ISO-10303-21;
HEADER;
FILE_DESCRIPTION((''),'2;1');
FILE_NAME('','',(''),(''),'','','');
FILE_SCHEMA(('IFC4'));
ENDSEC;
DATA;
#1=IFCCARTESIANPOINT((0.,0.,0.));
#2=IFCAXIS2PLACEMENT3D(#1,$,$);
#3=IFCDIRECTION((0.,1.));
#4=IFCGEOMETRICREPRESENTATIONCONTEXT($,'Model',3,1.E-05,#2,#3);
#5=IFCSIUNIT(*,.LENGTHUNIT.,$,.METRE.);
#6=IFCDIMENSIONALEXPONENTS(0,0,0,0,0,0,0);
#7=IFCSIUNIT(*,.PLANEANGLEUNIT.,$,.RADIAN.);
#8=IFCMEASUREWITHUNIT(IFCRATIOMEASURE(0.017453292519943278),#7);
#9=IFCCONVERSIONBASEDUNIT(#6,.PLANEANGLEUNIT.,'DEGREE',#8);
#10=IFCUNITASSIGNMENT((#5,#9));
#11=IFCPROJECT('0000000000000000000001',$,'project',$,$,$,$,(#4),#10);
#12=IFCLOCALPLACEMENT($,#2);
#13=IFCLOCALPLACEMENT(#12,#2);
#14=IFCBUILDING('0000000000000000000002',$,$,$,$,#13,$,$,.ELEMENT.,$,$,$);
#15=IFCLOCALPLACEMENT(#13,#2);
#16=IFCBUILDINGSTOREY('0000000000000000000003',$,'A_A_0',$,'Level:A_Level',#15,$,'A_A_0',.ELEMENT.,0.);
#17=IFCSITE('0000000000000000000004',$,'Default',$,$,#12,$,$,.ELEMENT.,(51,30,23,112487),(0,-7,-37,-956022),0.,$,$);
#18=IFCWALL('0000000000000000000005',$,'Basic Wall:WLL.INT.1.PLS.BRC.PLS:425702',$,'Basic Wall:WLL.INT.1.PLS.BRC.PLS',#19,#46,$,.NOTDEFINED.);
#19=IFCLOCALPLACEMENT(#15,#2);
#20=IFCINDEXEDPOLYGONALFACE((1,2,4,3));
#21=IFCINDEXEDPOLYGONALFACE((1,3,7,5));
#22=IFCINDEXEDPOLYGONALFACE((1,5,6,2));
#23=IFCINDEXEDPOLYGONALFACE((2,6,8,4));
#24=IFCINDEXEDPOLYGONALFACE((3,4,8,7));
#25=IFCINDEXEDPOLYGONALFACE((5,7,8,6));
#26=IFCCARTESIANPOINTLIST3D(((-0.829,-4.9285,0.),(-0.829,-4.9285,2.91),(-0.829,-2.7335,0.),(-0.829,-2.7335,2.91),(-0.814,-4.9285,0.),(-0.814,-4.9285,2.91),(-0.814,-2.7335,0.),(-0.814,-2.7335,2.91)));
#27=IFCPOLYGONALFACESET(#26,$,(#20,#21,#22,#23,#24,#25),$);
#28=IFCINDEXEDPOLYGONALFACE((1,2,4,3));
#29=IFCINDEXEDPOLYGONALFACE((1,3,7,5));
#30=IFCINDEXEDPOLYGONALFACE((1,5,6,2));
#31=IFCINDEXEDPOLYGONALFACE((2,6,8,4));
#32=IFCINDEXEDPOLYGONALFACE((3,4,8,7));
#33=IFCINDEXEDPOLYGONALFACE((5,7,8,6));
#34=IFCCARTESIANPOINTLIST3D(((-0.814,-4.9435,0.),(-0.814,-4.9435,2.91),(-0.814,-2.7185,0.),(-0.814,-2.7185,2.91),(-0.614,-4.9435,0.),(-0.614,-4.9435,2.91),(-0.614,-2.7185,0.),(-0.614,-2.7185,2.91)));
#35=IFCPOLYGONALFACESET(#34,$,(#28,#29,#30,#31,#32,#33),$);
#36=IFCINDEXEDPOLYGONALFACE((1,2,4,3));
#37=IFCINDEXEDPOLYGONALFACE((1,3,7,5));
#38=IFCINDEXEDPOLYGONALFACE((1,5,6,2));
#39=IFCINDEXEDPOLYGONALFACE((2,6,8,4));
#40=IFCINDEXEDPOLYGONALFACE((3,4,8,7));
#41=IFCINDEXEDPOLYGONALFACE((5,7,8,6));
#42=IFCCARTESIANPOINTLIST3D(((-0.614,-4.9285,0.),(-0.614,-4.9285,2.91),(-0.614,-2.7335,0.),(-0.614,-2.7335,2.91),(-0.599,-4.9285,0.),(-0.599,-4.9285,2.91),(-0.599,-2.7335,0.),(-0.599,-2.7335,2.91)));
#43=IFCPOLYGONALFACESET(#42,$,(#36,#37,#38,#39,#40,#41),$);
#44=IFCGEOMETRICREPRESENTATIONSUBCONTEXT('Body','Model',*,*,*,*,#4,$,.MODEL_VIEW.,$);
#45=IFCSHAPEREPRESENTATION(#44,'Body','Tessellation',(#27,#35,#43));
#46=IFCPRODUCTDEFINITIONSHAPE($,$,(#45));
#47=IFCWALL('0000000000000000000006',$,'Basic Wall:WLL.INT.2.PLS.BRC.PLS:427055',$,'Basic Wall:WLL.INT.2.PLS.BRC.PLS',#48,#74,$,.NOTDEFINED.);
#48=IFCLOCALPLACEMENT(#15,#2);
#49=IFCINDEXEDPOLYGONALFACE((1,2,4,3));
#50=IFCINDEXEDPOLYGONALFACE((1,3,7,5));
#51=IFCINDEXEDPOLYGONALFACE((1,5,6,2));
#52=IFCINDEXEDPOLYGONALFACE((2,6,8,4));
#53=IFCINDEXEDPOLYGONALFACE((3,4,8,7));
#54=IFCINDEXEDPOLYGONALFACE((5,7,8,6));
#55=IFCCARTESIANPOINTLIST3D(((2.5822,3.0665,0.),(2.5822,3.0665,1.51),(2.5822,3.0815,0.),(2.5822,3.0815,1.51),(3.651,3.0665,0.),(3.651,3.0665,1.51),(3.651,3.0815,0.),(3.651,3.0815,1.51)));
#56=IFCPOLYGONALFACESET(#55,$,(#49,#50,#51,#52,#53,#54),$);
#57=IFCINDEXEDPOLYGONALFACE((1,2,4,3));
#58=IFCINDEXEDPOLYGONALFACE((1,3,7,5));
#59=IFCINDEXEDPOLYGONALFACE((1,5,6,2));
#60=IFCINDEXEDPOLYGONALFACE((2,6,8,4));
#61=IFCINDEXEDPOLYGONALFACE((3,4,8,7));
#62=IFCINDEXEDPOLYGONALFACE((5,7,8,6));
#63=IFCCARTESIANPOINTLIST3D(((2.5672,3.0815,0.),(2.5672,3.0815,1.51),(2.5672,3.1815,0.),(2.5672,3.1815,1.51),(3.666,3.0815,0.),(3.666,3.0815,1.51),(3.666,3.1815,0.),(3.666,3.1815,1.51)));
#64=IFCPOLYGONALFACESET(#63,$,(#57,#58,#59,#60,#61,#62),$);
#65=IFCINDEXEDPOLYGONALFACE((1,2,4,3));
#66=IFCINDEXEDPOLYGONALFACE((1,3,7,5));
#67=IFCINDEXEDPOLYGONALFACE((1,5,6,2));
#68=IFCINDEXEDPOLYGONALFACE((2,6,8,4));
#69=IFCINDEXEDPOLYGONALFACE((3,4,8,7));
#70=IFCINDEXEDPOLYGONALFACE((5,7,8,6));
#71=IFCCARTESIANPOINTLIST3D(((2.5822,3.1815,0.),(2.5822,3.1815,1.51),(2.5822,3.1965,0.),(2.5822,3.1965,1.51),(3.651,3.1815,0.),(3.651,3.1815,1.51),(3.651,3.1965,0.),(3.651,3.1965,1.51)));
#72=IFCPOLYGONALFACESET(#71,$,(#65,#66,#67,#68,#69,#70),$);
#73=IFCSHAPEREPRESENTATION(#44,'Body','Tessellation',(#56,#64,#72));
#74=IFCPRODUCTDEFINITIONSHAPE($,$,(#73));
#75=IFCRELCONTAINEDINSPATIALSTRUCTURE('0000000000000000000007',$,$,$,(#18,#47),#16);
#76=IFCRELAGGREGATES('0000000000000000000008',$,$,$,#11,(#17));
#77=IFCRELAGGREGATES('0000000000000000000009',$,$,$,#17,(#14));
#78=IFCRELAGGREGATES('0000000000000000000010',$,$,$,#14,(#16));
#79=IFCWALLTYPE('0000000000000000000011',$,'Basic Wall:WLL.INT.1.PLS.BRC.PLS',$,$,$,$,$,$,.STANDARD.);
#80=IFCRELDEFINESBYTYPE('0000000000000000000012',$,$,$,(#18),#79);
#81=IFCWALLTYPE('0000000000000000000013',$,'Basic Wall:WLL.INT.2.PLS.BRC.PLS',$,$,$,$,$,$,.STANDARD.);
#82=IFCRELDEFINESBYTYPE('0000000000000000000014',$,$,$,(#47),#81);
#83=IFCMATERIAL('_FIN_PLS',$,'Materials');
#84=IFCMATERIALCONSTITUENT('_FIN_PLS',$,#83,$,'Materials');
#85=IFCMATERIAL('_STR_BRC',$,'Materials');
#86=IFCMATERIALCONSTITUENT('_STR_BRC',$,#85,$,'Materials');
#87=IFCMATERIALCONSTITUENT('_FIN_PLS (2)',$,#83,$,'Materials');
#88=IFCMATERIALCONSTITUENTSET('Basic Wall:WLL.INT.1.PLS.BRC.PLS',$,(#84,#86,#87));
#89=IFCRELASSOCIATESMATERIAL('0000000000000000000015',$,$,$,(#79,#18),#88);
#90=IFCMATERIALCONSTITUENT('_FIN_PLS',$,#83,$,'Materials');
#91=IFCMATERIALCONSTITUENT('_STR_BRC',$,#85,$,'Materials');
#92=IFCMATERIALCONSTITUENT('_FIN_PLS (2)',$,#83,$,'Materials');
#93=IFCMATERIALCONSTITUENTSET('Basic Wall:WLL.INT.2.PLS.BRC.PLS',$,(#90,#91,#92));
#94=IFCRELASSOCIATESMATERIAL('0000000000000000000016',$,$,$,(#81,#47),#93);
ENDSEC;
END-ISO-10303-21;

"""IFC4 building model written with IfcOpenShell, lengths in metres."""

from ifc_helpers import new_model, entity, si_unit, converted_unit, direction, frame, origin, place, context, subcontext, project, spatial, indexed_curve, outline, extrude, material, constituent, constituent_set, type_object, element, save


model = new_model("IFC4")

# Units and contexts
model_context = context("Model", 3, precision=1e-05, world=origin(), true_north=direction((0.0, 1.0)))
body_context = subcontext(model_context, "Body", "Model", "MODEL_VIEW")
ifc_project = project(units=[si_unit("LENGTHUNIT", "METRE"), converted_unit("PLANEANGLEUNIT", "DEGREE", entity("IfcRatioMeasure", 0.017453292519943278), si_unit("PLANEANGLEUNIT", "RADIAN"), dimensions=[0, 0, 0, 0, 0, 0, 0])], contexts=[model_context])

# Site, building, storey
site_placement = place(None, origin())
site = spatial("IfcSite", under=ifc_project, at=site_placement, Name="Default", CompositionType="ELEMENT", RefLatitude=(51, 30, 23, 112487), RefLongitude=(0, -7, -37, -956022), RefElevation=0.0)
building_placement = place(site_placement, origin())
building = spatial("IfcBuilding", under=site, at=building_placement, CompositionType="ELEMENT")
storey_placement = place(building_placement, origin())
storey = spatial("IfcBuildingStorey", under=building, at=storey_placement, Name="A_A_0", ObjectType="Level:A_Level", LongName="A_A_0", CompositionType="ELEMENT", Elevation=0.0)

# Wall
ifc_material_1 = material(Name="_FIN_PLS", Category="Materials")
ifc_constituent_1 = constituent(ifc_material_1, Name="_FIN_PLS", Category="Materials")
ifc_material_2 = material(Name="_STR_BRC", Category="Materials")
ifc_constituent_2 = constituent(ifc_material_2, Name="_STR_BRC", Category="Materials")
ifc_constituent_3 = constituent(ifc_material_1, Name="_FIN_PLS (2)", Category="Materials")
ifc_constituent_set_1 = constituent_set(constituents=[ifc_constituent_1, ifc_constituent_2, ifc_constituent_3], Name="Basic Wall:WLL.INT.1.PLS.BRC.PLS")
wall_type_1 = type_object("IfcWallType", Name="Basic Wall:WLL.INT.1.PLS.BRC.PLS", PredefinedType="STANDARD", material=ifc_constituent_set_1)
wall_1_placement = place(storey_placement, frame((-0.714, -2.7335, 0.0), z_axis=(0.0, 0.0, 1.0), x_axis=(0.0, -1.0, 0.0)))
element("IfcWall", 1, at=wall_1_placement, inside=storey, type_object=wall_type_1, material=ifc_constituent_set_1, Name="Basic Wall:WLL.INT.1.PLS.BRC.PLS:425702", ObjectType="Basic Wall:WLL.INT.1.PLS.BRC.PLS", PredefinedType="NOTDEFINED", context=body_context, shape_type="SweptSolid", body=[
    extrude(outline(indexed_curve([(-0.0075, -1.0975), (0.0075, -1.0975), (0.0075, 1.0975), (-0.0075, 1.0975), (-0.0075, -1.0975)], self_intersect=False)), frame((1.0975, -0.1075, 0.0), z_axis=(0.0, 0.0, 1.0), x_axis=(0.0, 1.0, 0.0)), (0.0, 0.0, 1.0), 2.91),
    extrude(outline(indexed_curve([(-1.1125, -0.1), (1.1125, -0.1), (1.1125, 0.1), (-1.1125, 0.1), (-1.1125, -0.1)], self_intersect=False)), frame((1.0975, 0.0, 0.0)), (0.0, 0.0, 1.0), 2.91),
    extrude(outline(indexed_curve([(-0.0075, -1.0975), (0.0075, -1.0975), (0.0075, 1.0975), (-0.0075, 1.0975), (-0.0075, -1.0975)], self_intersect=False)), frame((1.0975, 0.1075, 0.0), z_axis=(0.0, 0.0, 1.0), x_axis=(0.0, -1.0, 0.0)), (0.0, 0.0, 1.0), 2.91),
])

# Shared definitions
ifc_constituent_4 = constituent(ifc_material_1, Name="_FIN_PLS", Category="Materials")
ifc_constituent_5 = constituent(ifc_material_2, Name="_STR_BRC", Category="Materials")
ifc_constituent_6 = constituent(ifc_material_1, Name="_FIN_PLS (2)", Category="Materials")
ifc_constituent_set_2 = constituent_set(constituents=[ifc_constituent_4, ifc_constituent_5, ifc_constituent_6], Name="Basic Wall:WLL.INT.2.PLS.BRC.PLS")
wall_type_2 = type_object("IfcWallType", Name="Basic Wall:WLL.INT.2.PLS.BRC.PLS", PredefinedType="STANDARD", material=ifc_constituent_set_2)

# Wall
wall_2_placement = place(storey_placement, frame((2.5822, 3.1315, 0.0)))
element("IfcWall", 2, at=wall_2_placement, inside=storey, type_object=wall_type_2, material=ifc_constituent_set_2, Name="Basic Wall:WLL.INT.2.PLS.BRC.PLS:427055", ObjectType="Basic Wall:WLL.INT.2.PLS.BRC.PLS", PredefinedType="NOTDEFINED", context=body_context, shape_type="SweptSolid", body=[
    extrude(outline(indexed_curve([(-0.0075, -0.5344), (0.0075, -0.5344), (0.0075, 0.5344), (-0.0075, 0.5344), (-0.0075, -0.5344)], self_intersect=False)), frame((0.5344, -0.0575, 0.0), z_axis=(0.0, 0.0, 1.0), x_axis=(0.0, 1.0, 0.0)), (0.0, 0.0, 1.0), 1.51),
    extrude(outline(indexed_curve([(-0.5494, -0.05), (0.5494, -0.05), (0.5494, 0.05), (-0.5494, 0.05), (-0.5494, -0.05)], self_intersect=False)), frame((0.5344, 0.0, 0.0)), (0.0, 0.0, 1.0), 1.51),
    extrude(outline(indexed_curve([(-0.0075, -0.5344), (0.0075, -0.5344), (0.0075, 0.5344), (-0.0075, 0.5344), (-0.0075, -0.5344)], self_intersect=False)), frame((0.5344, 0.0575, 0.0), z_axis=(0.0, 0.0, 1.0), x_axis=(0.0, -1.0, 0.0)), (0.0, 0.0, 1.0), 1.51),
])

save(model, "model.ifc")
